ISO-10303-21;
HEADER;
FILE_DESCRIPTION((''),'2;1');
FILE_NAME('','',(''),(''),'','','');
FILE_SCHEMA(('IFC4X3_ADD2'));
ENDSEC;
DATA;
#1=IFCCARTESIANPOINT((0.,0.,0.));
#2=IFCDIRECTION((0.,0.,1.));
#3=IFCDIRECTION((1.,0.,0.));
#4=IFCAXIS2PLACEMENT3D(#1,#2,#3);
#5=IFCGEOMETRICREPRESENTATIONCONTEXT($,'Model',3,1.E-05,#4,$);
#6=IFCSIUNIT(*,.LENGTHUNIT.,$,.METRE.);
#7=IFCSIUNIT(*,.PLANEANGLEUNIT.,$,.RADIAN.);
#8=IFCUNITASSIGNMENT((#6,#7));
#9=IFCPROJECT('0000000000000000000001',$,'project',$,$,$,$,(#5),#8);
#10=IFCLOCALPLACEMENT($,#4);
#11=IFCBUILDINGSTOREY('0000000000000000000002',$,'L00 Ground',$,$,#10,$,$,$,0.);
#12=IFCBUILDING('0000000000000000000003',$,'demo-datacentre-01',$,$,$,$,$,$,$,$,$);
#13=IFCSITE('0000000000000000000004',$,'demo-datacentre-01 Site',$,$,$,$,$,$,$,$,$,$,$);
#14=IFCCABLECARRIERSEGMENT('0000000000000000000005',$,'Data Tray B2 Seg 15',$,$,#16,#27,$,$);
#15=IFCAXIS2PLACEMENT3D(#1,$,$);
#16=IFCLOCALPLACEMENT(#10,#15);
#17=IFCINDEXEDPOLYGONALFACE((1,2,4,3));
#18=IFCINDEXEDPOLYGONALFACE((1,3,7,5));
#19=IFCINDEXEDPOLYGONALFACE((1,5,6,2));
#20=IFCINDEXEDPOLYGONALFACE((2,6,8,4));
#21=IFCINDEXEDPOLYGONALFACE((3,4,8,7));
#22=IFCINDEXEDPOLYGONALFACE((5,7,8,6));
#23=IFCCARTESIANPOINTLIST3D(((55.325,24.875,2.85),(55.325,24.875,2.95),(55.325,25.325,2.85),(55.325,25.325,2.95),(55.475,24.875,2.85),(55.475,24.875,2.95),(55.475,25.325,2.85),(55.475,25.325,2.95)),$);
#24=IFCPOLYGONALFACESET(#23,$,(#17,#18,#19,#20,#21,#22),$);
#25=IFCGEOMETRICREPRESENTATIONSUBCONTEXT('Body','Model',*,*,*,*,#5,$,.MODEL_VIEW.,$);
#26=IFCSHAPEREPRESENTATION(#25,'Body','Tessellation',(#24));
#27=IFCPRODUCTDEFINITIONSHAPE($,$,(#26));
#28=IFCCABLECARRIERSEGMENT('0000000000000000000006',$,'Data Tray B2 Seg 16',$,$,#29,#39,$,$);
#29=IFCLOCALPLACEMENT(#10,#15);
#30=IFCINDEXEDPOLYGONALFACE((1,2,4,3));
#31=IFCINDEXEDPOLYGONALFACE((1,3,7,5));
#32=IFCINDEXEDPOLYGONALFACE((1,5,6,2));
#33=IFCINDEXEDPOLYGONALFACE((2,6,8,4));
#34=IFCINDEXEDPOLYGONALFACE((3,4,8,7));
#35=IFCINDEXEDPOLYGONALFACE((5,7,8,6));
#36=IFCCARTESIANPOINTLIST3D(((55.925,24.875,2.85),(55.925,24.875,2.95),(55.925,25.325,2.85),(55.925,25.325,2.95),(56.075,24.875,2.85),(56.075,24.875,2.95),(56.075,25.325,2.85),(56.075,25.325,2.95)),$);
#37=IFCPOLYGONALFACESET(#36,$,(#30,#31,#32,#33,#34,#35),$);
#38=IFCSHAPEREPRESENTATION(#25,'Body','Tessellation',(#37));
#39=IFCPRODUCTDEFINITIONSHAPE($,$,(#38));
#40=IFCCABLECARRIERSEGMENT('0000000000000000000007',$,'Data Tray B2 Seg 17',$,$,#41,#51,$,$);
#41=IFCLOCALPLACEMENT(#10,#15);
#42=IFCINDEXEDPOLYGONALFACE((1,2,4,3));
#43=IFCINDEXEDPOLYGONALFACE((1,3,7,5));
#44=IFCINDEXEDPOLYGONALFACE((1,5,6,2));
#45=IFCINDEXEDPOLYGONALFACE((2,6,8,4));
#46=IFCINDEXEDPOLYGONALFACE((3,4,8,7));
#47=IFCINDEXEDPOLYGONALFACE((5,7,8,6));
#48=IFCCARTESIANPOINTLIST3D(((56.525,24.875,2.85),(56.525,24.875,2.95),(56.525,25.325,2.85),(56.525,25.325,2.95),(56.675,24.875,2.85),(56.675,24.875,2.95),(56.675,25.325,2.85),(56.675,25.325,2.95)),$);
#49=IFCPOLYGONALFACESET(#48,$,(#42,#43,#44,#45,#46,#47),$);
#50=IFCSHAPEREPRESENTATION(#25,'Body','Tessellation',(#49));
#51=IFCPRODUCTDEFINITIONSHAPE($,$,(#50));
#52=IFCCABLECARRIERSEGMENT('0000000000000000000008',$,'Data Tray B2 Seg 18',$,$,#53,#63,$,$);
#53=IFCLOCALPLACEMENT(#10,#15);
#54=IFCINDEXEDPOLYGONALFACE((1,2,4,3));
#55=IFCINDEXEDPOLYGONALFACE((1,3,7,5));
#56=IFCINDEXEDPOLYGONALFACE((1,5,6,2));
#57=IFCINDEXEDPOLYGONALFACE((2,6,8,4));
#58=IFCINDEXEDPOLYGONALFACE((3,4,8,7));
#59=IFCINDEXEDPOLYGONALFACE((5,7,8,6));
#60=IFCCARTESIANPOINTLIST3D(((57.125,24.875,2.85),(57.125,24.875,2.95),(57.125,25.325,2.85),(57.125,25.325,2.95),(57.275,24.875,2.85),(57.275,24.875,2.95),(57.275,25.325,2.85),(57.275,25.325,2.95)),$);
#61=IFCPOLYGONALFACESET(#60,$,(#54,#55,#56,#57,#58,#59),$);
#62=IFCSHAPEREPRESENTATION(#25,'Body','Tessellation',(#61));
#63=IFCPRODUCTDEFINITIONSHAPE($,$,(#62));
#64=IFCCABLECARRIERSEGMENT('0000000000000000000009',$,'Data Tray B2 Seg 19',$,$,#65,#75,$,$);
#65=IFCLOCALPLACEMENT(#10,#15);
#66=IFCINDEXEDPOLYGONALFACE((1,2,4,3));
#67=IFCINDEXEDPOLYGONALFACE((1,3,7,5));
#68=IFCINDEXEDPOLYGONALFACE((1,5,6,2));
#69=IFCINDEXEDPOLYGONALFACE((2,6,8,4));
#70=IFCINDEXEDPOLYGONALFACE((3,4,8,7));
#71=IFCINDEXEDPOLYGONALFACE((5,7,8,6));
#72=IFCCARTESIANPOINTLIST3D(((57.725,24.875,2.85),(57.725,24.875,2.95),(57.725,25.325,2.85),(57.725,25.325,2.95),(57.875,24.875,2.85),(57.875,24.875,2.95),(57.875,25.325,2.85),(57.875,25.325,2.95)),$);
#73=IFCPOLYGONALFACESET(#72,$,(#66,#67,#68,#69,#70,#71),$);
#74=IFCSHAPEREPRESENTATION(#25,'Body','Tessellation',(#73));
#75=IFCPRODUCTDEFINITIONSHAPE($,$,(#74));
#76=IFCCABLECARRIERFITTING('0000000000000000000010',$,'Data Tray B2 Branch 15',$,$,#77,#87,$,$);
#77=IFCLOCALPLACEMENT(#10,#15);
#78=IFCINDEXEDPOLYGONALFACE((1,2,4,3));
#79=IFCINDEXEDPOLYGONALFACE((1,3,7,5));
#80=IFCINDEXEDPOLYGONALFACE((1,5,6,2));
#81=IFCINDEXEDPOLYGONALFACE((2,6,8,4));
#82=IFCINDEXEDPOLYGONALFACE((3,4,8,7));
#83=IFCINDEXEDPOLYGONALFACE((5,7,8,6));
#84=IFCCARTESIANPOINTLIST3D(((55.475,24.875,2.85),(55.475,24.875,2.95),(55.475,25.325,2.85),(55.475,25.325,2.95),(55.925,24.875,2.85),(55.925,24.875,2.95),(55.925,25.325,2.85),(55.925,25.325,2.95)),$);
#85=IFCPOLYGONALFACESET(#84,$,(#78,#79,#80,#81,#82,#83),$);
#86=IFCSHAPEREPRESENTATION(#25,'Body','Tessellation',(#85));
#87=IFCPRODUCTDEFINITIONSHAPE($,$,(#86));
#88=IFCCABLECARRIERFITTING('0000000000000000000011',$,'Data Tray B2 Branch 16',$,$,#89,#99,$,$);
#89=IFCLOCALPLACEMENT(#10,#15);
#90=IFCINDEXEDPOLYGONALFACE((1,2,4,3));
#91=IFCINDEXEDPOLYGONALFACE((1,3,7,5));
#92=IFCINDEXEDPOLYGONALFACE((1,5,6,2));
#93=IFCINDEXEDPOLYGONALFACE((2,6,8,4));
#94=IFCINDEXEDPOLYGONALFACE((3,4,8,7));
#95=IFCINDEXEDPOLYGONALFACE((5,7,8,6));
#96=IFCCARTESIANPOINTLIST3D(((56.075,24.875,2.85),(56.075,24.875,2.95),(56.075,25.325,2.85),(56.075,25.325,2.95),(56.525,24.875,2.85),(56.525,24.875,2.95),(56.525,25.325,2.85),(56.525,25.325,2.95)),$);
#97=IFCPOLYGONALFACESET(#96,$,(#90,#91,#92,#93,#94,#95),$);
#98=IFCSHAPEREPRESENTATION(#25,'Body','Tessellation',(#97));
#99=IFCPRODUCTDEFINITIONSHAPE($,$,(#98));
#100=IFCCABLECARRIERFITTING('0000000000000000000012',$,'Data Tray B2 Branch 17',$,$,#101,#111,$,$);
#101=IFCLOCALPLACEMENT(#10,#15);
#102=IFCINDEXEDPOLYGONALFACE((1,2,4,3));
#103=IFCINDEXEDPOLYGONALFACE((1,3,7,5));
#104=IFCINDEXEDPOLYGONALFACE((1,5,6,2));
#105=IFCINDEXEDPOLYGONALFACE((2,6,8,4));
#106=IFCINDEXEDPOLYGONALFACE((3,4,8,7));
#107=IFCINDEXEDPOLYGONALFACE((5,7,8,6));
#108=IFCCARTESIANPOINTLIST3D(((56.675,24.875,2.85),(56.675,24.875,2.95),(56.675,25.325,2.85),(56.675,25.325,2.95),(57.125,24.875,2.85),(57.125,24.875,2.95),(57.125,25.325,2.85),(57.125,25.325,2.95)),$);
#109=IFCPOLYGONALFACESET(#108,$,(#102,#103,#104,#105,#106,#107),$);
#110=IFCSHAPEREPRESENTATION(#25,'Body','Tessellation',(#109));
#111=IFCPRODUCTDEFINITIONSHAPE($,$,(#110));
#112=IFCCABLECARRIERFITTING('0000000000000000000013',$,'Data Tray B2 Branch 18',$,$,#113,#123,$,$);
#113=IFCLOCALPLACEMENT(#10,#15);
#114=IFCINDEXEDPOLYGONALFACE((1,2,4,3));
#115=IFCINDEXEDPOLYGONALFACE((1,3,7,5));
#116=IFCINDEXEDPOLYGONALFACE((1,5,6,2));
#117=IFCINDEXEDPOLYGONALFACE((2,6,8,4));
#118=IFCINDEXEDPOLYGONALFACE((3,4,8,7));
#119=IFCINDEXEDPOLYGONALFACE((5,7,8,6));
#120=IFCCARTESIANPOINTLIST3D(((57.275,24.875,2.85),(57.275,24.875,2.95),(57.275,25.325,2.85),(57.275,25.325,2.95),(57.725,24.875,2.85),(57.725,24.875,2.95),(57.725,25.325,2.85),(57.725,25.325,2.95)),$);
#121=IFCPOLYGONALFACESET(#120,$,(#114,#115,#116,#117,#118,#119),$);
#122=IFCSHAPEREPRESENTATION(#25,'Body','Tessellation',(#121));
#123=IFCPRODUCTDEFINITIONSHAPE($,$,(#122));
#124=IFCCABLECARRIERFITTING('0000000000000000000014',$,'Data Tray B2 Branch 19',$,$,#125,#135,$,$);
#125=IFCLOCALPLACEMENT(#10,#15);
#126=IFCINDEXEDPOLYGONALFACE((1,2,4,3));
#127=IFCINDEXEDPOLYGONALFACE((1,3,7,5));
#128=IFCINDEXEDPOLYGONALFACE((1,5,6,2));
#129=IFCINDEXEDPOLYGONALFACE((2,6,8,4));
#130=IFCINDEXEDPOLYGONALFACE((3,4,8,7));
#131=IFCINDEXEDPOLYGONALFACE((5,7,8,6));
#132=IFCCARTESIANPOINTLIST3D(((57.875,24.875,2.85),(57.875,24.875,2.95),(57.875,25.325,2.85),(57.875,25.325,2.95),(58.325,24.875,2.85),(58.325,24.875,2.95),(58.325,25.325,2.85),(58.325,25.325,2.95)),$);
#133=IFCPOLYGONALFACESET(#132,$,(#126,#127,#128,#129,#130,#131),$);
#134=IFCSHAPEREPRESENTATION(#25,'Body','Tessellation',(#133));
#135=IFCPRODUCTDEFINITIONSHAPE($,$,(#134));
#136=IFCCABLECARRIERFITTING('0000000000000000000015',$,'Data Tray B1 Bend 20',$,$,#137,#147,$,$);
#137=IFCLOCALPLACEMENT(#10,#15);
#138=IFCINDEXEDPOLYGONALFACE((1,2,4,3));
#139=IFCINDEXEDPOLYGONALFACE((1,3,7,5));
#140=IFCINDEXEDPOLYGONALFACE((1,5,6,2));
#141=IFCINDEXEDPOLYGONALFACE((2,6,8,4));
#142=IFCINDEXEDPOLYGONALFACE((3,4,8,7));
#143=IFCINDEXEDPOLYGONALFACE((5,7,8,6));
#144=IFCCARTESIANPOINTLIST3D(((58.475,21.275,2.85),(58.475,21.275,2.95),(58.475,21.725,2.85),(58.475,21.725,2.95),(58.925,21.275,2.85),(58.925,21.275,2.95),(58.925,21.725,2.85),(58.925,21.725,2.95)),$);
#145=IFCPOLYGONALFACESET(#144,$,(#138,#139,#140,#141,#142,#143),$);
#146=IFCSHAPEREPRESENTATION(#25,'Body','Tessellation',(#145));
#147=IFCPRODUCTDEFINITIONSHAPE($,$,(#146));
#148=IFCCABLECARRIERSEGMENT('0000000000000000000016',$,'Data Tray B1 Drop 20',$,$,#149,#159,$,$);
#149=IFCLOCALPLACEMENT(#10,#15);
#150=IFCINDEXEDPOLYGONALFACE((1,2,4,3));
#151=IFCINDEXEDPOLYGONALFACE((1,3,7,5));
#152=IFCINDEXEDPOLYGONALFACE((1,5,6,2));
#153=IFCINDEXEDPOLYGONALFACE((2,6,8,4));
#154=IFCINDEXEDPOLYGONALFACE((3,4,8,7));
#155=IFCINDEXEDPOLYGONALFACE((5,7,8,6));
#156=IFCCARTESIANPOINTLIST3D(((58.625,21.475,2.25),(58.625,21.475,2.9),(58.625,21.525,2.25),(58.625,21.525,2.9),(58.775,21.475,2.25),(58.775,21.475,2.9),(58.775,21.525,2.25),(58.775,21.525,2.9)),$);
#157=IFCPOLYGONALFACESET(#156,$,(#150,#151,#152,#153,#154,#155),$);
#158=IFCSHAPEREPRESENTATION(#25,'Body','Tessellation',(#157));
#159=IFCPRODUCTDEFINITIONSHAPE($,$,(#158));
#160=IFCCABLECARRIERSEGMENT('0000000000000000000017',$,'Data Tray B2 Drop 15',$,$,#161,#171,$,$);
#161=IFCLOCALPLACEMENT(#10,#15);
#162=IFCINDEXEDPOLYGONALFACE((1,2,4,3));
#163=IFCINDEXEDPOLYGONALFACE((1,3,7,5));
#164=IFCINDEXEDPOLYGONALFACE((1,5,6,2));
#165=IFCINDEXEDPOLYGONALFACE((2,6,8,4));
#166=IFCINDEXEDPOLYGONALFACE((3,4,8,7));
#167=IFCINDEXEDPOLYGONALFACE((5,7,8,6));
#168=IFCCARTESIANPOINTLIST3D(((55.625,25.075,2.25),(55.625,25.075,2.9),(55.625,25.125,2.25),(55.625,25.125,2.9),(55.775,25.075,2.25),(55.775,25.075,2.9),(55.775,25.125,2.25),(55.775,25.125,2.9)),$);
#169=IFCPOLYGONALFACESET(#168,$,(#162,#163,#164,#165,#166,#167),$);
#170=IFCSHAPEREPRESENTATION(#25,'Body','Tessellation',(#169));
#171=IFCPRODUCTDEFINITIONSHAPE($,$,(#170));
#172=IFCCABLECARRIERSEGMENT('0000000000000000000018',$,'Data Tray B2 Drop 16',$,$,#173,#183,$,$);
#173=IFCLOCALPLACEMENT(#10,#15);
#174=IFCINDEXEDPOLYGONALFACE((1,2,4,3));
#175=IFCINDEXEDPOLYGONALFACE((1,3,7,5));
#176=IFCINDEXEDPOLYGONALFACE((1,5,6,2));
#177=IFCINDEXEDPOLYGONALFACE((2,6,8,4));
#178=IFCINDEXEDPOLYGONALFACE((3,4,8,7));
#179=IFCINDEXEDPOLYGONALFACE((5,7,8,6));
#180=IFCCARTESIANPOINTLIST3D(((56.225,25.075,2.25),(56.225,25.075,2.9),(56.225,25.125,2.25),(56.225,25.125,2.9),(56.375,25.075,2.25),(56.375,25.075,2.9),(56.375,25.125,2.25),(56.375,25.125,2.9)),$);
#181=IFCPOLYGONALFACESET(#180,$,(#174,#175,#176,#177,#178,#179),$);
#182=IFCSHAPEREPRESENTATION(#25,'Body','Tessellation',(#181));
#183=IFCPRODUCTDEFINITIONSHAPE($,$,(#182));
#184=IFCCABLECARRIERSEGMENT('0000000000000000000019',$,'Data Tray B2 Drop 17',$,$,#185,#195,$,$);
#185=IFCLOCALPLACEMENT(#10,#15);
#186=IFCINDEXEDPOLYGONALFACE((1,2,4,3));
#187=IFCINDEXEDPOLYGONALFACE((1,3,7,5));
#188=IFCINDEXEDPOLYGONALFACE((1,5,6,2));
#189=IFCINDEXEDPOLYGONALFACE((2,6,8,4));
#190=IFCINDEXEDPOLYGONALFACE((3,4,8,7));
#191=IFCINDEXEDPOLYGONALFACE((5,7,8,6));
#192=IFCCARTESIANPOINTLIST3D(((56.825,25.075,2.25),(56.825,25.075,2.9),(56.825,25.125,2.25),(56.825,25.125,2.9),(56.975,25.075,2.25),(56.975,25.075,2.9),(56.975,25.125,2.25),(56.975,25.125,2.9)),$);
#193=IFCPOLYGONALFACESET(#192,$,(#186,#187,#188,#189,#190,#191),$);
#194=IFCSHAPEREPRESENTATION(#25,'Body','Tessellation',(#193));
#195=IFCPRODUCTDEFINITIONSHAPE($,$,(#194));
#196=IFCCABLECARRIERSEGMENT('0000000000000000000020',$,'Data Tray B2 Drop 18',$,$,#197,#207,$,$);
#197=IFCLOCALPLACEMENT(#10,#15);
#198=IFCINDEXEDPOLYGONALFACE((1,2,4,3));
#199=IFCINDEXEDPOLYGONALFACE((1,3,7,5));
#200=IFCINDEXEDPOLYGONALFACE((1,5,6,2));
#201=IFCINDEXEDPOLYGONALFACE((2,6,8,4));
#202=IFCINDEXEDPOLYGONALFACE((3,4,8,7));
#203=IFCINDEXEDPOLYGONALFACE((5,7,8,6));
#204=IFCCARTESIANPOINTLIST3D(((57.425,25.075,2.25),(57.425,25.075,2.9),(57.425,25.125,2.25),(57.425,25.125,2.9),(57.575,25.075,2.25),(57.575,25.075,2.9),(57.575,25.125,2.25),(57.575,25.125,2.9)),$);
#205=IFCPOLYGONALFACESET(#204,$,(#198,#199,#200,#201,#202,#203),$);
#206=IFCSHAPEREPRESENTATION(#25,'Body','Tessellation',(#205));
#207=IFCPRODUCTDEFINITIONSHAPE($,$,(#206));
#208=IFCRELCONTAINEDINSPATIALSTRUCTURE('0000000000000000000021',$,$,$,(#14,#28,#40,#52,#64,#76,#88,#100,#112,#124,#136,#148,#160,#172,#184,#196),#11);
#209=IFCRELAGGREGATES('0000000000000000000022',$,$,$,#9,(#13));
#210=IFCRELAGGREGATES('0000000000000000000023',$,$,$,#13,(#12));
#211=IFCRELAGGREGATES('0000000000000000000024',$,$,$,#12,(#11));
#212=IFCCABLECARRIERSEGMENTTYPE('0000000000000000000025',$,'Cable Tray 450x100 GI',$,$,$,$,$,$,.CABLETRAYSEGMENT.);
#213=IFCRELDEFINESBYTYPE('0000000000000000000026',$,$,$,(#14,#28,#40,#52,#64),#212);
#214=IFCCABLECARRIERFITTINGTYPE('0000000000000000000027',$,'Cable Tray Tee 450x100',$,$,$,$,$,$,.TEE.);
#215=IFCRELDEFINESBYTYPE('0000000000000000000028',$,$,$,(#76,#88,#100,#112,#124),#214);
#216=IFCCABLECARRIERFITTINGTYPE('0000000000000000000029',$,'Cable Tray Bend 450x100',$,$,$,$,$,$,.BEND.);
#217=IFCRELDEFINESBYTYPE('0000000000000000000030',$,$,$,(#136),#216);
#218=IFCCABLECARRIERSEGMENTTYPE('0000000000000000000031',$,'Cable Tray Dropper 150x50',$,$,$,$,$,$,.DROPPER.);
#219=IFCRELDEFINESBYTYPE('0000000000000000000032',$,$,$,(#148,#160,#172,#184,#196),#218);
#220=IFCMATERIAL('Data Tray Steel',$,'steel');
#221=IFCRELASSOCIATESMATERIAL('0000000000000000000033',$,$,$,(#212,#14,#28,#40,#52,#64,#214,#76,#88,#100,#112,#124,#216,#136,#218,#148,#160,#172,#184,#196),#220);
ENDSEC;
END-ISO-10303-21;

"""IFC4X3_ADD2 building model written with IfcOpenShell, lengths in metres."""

from ifc_helpers import new_model, si_unit, frame, origin_with_axes, place, context, subcontext, project, spatial, rectangle, extrude, material, type_object, element, save


model = new_model("IFC4X3_ADD2")

# Units and contexts
model_context = context("Model", 3, precision=1e-05, world=origin_with_axes())
body_context = subcontext(model_context, "Body", "Model", "MODEL_VIEW")
ifc_project = project(units=[si_unit("LENGTHUNIT", "METRE"), si_unit("PLANEANGLEUNIT", "RADIAN")], contexts=[model_context])

# Site, building, storey
site = spatial("IfcSite", under=ifc_project, Name="demo-datacentre-01 Site")
building = spatial("IfcBuilding", under=site, Name="demo-datacentre-01")
storey_placement = place(None, origin_with_axes())
storey = spatial("IfcBuildingStorey", under=building, at=storey_placement, Name="L00 Ground", Elevation=0.0)

# Cable carrier segments
ifc_material_1 = material(Name="Data Tray Steel", Category="steel")
cable_carrier_segment_type_1 = type_object("IfcCableCarrierSegmentType", Name="Cable Tray 450x100 GI", PredefinedType="CABLETRAYSEGMENT", material=ifc_material_1)
for number, where, z_axis, x_axis, name in (
    (1, (55.325, 25.1, 2.9), (1.0, 0.0, 0.0), (0.0, 1.0, 0.0), "Data Tray B2 Seg 15"),
    (2, (55.925, 25.1, 2.9), (1.0, 0.0, 0.0), (0.0, 1.0, 0.0), "Data Tray B2 Seg 16"),
    (3, (56.525, 25.1, 2.9), (1.0, 0.0, 0.0), (0.0, 1.0, 0.0), "Data Tray B2 Seg 17"),
    (4, (57.125, 25.1, 2.9), (1.0, 0.0, 0.0), (0.0, 1.0, 0.0), "Data Tray B2 Seg 18"),
):
    element("IfcCableCarrierSegment", number, at=place(storey_placement, frame(where, z_axis=z_axis, x_axis=x_axis)), inside=storey, type_object=cable_carrier_segment_type_1, material=ifc_material_1, Name=name, context=body_context, shape_type="SweptSolid", body=[
        extrude(rectangle(XDim=0.45, YDim=0.1), origin_with_axes(), (0.0, 0.0, 1.0), 0.15),
    ])
cable_carrier_segment_placement = place(storey_placement, frame((57.725, 25.1, 2.9), z_axis=(1.0, 0.0, 0.0), x_axis=(0.0, 1.0, 0.0)))
element("IfcCableCarrierSegment", 5, at=cable_carrier_segment_placement, inside=storey, type_object=cable_carrier_segment_type_1, material=ifc_material_1, Name="Data Tray B2 Seg 19", context=body_context, shape_type="SweptSolid", body=[
    extrude(rectangle(XDim=0.45, YDim=0.1), origin_with_axes(), (0.0, 0.0, 1.0), 0.15),
])

# Cable carrier fittings
cable_carrier_fitting_type_1 = type_object("IfcCableCarrierFittingType", Name="Cable Tray Tee 450x100", PredefinedType="TEE", material=ifc_material_1)
for number, where, z_axis, x_axis, name in (
    (6, (55.7, 25.1, 2.85), (0.0, 0.0, 1.0), (1.0, 0.0, 0.0), "Data Tray B2 Branch 15"),
    (7, (56.3, 25.1, 2.85), (0.0, 0.0, 1.0), (1.0, 0.0, 0.0), "Data Tray B2 Branch 16"),
    (8, (56.9, 25.1, 2.85), (0.0, 0.0, 1.0), (1.0, 0.0, 0.0), "Data Tray B2 Branch 17"),
    (9, (57.5, 25.1, 2.85), (0.0, 0.0, 1.0), (1.0, 0.0, 0.0), "Data Tray B2 Branch 18"),
    (10, (58.1, 25.1, 2.85), (0.0, 0.0, 1.0), (1.0, 0.0, 0.0), "Data Tray B2 Branch 19"),
):
    element("IfcCableCarrierFitting", number, at=place(storey_placement, frame(where, z_axis=z_axis, x_axis=x_axis)), inside=storey, type_object=cable_carrier_fitting_type_1, material=ifc_material_1, Name=name, context=body_context, shape_type="SweptSolid", body=[
        extrude(rectangle(XDim=0.45, YDim=0.45), origin_with_axes(), (0.0, 0.0, 1.0), 0.1),
    ])
cable_carrier_fitting_type_2 = type_object("IfcCableCarrierFittingType", Name="Cable Tray Bend 450x100", PredefinedType="BEND", material=ifc_material_1)
cable_carrier_fitting_placement = place(storey_placement, frame((58.7, 21.5, 2.85), z_axis=(0.0, 0.0, 1.0), x_axis=(1.0, 0.0, 0.0)))
element("IfcCableCarrierFitting", 11, at=cable_carrier_fitting_placement, inside=storey, type_object=cable_carrier_fitting_type_2, material=ifc_material_1, Name="Data Tray B1 Bend 20", context=body_context, shape_type="SweptSolid", body=[
    extrude(rectangle(XDim=0.45, YDim=0.45), origin_with_axes(), (0.0, 0.0, 1.0), 0.1),
])

# Cable carrier segments
cable_carrier_segment_type_2 = type_object("IfcCableCarrierSegmentType", Name="Cable Tray Dropper 150x50", PredefinedType="DROPPER", material=ifc_material_1)
for number, where, z_axis, x_axis, name in (
    (12, (58.7, 21.5, 2.9), (0.0, 0.0, -1.0), (1.0, 0.0, 0.0), "Data Tray B1 Drop 20"),
    (13, (55.7, 25.1, 2.9), (0.0, 0.0, -1.0), (1.0, 0.0, 0.0), "Data Tray B2 Drop 15"),
    (14, (56.3, 25.1, 2.9), (0.0, 0.0, -1.0), (1.0, 0.0, 0.0), "Data Tray B2 Drop 16"),
    (15, (56.9, 25.1, 2.9), (0.0, 0.0, -1.0), (1.0, 0.0, 0.0), "Data Tray B2 Drop 17"),
    (16, (57.5, 25.1, 2.9), (0.0, 0.0, -1.0), (1.0, 0.0, 0.0), "Data Tray B2 Drop 18"),
):
    element("IfcCableCarrierSegment", number, at=place(storey_placement, frame(where, z_axis=z_axis, x_axis=x_axis)), inside=storey, type_object=cable_carrier_segment_type_2, material=ifc_material_1, Name=name, context=body_context, shape_type="SweptSolid", body=[
        extrude(rectangle(XDim=0.15, YDim=0.05), origin_with_axes(), (0.0, 0.0, 1.0), 0.65),
    ])

save(model, "model.ifc")
